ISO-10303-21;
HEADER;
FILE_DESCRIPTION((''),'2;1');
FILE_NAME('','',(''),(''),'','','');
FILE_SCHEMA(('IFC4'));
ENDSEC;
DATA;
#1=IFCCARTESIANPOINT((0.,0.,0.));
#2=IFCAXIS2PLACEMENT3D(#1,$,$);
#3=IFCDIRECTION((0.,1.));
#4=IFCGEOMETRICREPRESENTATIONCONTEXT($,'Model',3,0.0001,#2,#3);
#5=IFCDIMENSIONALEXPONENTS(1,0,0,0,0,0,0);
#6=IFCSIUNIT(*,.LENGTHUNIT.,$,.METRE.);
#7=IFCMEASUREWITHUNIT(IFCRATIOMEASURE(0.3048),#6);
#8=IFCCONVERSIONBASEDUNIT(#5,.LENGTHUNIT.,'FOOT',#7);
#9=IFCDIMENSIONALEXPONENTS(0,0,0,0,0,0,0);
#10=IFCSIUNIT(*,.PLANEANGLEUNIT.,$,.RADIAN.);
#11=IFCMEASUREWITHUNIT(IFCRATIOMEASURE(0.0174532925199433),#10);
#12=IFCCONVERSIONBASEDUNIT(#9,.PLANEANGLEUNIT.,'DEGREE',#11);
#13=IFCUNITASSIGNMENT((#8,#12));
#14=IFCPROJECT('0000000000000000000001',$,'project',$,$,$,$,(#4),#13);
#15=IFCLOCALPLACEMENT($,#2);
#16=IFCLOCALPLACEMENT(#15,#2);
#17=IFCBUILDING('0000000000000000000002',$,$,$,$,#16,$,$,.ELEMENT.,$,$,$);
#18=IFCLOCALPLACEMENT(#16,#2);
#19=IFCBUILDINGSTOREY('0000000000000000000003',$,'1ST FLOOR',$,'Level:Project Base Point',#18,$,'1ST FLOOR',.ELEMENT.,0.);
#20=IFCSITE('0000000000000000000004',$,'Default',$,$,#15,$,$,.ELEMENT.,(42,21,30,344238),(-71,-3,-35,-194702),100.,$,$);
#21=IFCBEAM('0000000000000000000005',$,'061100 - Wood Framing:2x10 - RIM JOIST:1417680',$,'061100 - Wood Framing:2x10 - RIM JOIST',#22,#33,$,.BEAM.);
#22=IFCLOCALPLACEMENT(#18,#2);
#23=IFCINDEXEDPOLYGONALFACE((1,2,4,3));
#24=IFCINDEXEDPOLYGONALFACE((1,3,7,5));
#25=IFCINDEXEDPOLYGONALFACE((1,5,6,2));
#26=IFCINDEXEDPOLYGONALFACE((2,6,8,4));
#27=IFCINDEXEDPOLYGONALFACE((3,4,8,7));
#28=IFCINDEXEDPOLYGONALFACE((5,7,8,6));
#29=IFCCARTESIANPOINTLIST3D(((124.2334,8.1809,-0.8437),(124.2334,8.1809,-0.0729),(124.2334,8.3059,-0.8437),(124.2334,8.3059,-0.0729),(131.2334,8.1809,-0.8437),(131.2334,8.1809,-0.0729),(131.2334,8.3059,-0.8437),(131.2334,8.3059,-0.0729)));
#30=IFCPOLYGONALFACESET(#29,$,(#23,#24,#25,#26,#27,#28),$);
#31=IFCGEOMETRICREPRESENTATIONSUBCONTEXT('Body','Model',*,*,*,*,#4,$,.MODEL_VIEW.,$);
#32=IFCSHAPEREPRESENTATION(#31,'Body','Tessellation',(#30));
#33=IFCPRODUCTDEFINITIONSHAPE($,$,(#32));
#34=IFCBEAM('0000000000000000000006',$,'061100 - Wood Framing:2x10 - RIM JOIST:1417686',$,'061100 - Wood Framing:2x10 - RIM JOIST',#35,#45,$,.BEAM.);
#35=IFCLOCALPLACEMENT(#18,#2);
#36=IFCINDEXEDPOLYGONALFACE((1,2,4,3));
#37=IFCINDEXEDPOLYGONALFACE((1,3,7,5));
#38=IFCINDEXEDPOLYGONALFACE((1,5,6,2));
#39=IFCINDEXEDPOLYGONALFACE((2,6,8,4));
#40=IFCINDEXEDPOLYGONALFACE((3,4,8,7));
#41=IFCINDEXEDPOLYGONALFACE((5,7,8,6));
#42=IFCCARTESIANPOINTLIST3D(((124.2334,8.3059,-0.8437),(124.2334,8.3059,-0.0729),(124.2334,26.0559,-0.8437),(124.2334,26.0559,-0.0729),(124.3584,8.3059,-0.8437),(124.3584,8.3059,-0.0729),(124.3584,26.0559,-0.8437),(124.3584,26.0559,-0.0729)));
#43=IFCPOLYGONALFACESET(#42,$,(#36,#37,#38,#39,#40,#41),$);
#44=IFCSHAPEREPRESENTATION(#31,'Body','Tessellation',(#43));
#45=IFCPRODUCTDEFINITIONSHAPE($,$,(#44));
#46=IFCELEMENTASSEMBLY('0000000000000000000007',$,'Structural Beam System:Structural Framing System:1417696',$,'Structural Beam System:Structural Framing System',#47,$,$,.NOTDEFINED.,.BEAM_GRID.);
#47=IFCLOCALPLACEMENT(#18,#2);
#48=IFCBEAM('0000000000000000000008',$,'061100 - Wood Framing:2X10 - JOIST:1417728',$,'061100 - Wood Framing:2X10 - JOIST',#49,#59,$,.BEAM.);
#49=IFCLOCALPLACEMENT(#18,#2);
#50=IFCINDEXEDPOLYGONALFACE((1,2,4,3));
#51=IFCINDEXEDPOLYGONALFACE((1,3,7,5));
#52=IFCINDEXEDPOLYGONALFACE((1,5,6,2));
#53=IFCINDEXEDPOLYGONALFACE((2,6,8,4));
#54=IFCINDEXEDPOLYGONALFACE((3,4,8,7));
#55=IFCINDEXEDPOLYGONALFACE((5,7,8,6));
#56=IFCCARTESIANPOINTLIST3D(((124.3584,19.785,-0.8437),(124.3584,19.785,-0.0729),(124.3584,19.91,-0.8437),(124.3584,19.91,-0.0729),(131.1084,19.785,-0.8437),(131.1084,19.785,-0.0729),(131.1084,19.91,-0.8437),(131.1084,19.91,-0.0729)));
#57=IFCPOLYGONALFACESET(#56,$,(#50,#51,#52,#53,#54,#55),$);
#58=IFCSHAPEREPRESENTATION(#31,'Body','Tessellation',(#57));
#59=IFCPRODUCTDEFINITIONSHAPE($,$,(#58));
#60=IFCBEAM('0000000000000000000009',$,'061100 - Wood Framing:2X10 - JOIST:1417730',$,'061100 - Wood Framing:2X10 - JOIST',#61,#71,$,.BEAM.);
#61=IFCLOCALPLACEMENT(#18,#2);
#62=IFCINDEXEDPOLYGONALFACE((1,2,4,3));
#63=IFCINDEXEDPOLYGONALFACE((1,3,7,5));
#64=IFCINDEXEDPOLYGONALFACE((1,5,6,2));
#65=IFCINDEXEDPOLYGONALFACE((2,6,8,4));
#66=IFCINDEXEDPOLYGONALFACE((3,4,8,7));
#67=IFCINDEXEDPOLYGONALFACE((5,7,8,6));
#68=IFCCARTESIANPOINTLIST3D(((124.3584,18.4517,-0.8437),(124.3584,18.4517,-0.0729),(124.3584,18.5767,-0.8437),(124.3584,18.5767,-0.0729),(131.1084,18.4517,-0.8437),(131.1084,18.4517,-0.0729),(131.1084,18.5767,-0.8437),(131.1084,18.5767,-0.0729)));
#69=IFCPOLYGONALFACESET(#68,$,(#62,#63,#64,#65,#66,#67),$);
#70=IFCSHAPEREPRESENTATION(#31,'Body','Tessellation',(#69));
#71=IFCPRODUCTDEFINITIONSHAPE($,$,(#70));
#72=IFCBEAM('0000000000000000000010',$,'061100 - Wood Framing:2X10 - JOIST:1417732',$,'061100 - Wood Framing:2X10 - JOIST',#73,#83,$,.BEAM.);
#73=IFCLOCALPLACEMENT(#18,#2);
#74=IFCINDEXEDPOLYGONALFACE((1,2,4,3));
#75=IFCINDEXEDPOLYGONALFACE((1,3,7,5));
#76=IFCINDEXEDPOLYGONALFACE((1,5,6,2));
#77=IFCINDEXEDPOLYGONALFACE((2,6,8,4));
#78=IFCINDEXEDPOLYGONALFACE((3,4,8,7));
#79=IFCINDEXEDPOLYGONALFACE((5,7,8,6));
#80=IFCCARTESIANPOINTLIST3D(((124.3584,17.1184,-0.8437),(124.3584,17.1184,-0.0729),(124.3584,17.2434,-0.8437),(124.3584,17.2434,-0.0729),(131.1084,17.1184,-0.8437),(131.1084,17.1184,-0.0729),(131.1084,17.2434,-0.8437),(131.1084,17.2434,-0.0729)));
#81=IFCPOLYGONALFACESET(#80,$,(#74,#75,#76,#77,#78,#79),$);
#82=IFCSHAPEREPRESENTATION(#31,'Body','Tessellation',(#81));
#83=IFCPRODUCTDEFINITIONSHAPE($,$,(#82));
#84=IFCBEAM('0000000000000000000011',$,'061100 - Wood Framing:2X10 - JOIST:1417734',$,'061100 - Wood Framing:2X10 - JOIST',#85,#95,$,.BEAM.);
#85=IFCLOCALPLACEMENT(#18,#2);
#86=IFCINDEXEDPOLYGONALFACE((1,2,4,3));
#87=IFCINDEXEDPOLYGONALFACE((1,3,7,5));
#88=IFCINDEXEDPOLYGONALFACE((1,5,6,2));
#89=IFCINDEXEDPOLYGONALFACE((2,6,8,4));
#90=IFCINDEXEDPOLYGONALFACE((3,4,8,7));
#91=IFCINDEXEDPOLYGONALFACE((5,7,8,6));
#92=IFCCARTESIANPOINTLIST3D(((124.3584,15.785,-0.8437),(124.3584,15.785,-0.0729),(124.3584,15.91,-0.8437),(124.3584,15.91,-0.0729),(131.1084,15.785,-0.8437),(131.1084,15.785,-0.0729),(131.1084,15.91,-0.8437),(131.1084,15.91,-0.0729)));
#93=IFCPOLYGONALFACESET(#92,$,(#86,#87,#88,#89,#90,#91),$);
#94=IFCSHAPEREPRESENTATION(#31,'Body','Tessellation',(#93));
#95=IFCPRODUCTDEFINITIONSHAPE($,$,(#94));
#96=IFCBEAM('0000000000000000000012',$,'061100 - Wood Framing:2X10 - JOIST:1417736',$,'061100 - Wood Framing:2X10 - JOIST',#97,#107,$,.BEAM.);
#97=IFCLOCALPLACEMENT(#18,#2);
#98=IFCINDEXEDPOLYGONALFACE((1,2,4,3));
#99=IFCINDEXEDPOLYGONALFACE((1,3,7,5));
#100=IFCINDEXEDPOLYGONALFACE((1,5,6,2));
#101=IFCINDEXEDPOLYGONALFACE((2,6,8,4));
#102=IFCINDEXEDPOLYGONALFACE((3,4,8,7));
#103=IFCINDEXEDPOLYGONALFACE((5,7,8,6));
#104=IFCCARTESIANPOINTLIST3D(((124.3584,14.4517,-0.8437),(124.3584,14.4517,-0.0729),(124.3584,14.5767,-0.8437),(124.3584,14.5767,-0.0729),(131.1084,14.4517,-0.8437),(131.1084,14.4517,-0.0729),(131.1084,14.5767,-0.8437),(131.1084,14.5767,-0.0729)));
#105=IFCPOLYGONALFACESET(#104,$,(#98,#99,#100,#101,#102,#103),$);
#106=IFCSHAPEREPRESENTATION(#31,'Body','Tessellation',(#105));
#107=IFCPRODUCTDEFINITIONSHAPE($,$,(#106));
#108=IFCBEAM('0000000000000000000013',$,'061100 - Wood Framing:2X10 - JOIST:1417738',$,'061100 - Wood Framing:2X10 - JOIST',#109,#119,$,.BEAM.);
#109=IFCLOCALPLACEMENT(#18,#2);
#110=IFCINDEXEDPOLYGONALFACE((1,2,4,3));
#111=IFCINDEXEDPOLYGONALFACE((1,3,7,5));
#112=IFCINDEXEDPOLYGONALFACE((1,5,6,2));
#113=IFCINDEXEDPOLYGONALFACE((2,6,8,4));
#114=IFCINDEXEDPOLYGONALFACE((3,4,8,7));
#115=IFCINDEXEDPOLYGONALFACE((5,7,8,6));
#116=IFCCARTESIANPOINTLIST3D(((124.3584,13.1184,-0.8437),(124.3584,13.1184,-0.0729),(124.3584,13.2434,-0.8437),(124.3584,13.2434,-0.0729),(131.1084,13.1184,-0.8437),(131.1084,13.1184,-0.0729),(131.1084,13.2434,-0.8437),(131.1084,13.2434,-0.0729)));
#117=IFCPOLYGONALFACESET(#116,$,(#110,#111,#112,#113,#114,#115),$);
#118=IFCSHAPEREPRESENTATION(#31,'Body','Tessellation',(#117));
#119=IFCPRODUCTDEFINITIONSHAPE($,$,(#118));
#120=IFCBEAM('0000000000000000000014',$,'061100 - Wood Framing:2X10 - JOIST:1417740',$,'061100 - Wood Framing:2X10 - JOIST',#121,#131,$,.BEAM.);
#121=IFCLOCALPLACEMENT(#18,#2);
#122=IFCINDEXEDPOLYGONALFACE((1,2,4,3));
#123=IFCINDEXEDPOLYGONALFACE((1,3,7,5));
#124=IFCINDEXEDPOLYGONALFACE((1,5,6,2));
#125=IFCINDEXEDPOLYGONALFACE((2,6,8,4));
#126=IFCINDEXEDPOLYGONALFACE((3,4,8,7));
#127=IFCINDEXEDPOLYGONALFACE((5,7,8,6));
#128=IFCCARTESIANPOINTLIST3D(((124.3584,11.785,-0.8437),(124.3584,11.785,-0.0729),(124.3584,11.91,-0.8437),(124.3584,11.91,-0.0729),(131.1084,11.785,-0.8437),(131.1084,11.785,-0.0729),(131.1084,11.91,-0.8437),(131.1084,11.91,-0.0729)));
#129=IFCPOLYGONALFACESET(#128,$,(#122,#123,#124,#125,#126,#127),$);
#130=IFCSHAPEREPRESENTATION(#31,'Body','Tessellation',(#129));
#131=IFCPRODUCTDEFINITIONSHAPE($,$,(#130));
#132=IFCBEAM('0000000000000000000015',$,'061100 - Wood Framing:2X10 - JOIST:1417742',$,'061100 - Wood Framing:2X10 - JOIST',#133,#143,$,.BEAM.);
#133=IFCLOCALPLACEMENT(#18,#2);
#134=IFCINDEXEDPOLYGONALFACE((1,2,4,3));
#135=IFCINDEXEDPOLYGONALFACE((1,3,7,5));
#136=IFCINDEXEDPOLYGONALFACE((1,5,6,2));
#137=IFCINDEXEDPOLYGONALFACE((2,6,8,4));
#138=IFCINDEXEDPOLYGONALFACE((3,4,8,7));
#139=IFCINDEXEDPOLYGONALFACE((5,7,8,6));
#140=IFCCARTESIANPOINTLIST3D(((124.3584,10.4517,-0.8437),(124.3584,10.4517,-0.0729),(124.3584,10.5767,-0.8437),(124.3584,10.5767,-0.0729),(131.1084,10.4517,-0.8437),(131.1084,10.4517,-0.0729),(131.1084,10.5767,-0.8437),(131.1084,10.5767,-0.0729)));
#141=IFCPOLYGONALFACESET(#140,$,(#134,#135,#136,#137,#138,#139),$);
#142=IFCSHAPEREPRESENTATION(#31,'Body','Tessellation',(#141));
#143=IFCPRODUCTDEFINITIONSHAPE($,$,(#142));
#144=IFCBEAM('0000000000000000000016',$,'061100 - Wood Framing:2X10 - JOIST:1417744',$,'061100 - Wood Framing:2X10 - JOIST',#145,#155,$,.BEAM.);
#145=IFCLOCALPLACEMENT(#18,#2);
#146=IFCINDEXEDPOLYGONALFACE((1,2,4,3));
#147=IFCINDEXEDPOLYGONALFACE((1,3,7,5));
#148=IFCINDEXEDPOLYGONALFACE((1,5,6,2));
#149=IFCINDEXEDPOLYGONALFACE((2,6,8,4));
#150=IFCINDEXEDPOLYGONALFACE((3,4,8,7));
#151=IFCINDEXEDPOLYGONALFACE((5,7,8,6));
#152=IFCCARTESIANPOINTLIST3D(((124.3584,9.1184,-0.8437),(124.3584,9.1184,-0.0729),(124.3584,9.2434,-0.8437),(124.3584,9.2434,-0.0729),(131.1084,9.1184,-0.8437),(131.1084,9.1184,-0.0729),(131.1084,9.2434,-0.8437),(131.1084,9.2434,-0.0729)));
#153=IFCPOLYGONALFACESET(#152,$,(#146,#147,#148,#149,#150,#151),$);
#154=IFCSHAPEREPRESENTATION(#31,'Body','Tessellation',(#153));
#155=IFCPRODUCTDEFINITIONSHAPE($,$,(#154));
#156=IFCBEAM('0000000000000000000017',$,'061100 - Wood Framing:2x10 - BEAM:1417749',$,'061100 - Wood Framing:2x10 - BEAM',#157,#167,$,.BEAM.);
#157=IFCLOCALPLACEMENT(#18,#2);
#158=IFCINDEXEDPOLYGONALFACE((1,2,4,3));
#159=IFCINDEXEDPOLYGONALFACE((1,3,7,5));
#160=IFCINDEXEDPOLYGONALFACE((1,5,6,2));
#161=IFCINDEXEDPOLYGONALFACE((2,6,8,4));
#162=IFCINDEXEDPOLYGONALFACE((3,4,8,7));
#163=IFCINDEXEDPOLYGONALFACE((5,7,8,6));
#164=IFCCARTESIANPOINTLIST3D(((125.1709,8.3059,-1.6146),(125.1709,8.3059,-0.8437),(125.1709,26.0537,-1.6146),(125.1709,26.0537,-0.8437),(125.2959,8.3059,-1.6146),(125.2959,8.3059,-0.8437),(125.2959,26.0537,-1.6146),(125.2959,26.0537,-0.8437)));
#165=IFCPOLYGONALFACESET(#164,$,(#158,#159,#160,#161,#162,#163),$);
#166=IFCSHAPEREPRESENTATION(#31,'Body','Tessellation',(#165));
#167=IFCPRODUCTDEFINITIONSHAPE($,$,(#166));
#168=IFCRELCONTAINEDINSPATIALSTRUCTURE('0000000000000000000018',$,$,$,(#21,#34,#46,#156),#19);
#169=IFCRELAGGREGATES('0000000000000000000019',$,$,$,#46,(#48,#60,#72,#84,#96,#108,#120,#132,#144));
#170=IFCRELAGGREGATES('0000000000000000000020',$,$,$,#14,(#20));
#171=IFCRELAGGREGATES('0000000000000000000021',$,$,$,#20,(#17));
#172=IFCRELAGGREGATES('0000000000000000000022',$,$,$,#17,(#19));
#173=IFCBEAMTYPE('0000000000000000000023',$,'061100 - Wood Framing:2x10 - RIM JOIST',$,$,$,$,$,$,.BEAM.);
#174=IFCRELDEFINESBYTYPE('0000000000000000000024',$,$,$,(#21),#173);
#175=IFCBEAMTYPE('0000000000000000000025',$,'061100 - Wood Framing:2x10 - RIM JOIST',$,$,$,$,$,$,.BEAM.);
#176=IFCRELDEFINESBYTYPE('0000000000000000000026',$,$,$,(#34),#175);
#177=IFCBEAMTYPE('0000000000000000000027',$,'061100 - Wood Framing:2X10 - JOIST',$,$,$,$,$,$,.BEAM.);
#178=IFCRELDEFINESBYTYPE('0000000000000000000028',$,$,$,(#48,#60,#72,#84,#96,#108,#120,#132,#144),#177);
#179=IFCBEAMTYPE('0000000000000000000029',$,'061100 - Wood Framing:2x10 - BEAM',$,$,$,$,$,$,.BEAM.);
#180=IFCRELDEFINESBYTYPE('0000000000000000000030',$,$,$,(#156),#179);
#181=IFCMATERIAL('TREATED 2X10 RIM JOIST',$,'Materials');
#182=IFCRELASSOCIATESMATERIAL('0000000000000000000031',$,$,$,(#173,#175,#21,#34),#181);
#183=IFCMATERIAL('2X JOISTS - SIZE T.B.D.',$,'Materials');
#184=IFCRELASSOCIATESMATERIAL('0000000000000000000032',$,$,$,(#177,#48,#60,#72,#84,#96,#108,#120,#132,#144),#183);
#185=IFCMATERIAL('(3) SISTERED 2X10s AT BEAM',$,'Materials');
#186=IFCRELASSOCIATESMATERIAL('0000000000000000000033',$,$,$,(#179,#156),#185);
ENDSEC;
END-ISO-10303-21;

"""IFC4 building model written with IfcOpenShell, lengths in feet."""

from ifc_helpers import new_model, entity, si_unit, converted_unit, direction, frame, frame_2d, origin, origin_2d_with_axis, place, context, subcontext, project, spatial, rectangle, extrude, source, transform, mapped, material, material_profile, profile_set, profile_usage, type_object, type_shapes, element, aggregate, save


model = new_model("IFC4")

# Units and contexts
model_context = context("Model", 3, precision=0.0001, world=origin(), true_north=direction((0.0, 1.0)))
body_context = subcontext(model_context, "Body", "Model", "MODEL_VIEW")
ifc_project = project(units=[converted_unit("LENGTHUNIT", "FOOT", entity("IfcRatioMeasure", 0.3048), si_unit("LENGTHUNIT", "METRE"), dimensions=[1, 0, 0, 0, 0, 0, 0]), converted_unit("PLANEANGLEUNIT", "DEGREE", entity("IfcRatioMeasure", 0.0174532925199433), si_unit("PLANEANGLEUNIT", "RADIAN"), dimensions=[0, 0, 0, 0, 0, 0, 0])], contexts=[model_context])

# Site, building, storey
site_placement = place(None, origin())
site = spatial("IfcSite", under=ifc_project, at=site_placement, Name="Default", CompositionType="ELEMENT", RefLatitude=(42, 21, 30, 344238), RefLongitude=(-71, -3, -35, -194702), RefElevation=100.0)
building_placement = place(site_placement, origin())
building = spatial("IfcBuilding", under=site, at=building_placement, CompositionType="ELEMENT")
storey_placement = place(building_placement, origin())
storey = spatial("IfcBuildingStorey", under=building, at=storey_placement, Name="1ST FLOOR", ObjectType="Level:Project Base Point", LongName="1ST FLOOR", CompositionType="ELEMENT", Elevation=0.0)

# Beams
ifc_material_1 = material(Name="TREATED 2X10 RIM JOIST", Category="Materials")
ifc_material_profile_1 = material_profile(ifc_material_1, rectangle(XDim=0.7708, YDim=0.125, at=origin_2d_with_axis()), Name="2x10 - RIM JOIST")
ifc_profile_set_1 = profile_set([ifc_material_profile_1], Name="2x10 - RIM JOIST")
ifc_profile_usage_1 = profile_usage(ifc_profile_set_1, cardinal=8)
beam_type_1 = type_object("IfcBeamType", Name="061100 - Wood Framing:2x10 - RIM JOIST", PredefinedType="BEAM", material=ifc_profile_set_1)
shared_shape_1 = source(origin(), body_context, "Body", "SweptSolid", [
    extrude(rectangle(XDim=0.7708, YDim=0.125, at=origin_2d_with_axis()), frame((-3.5, 0.0, 0.0), z_axis=(1.0, 0.0, 0.0), x_axis=(0.0, 0.0, -1.0)), (0.0, 0.0, 1.0), 7.0),
])
type_shapes(beam_type_1, [shared_shape_1])
beam_1_placement = place(storey_placement, frame((127.7334, 8.2434, -0.4583)))
element("IfcBeam", 1, at=beam_1_placement, inside=storey, type_object=beam_type_1, material=ifc_profile_usage_1, Name="061100 - Wood Framing:2x10 - RIM JOIST:1417680", ObjectType="061100 - Wood Framing:2x10 - RIM JOIST", PredefinedType="BEAM", context=body_context, shape_type="MappedRepresentation", body=[
    mapped(shared_shape_1, transform((0.0, 0.0, 0.0), scale=1.0)),
])
ifc_profile_usage_2 = profile_usage(ifc_profile_set_1, cardinal=8)
beam_type_2 = type_object("IfcBeamType", Name="061100 - Wood Framing:2x10 - RIM JOIST", PredefinedType="BEAM", material=ifc_profile_set_1)
shared_shape_2 = source(origin(), body_context, "Body", "SweptSolid", [
    extrude(rectangle(XDim=0.7708, YDim=0.125, at=frame_2d((0.0, 0.0), x_axis=(1.0, 0.0))), frame((-8.875, 0.0, 0.0), z_axis=(1.0, 0.0, 0.0), x_axis=(0.0, 0.0, -1.0)), (0.0, 0.0, 1.0), 17.75),
])
type_shapes(beam_type_2, [shared_shape_2])
beam_2_placement = place(storey_placement, frame((124.2959, 17.1809, -0.4583), z_axis=(0.0, 0.0, 1.0), x_axis=(0.0, -1.0, 0.0)))
element("IfcBeam", 2, at=beam_2_placement, inside=storey, type_object=beam_type_2, material=ifc_profile_usage_2, Name="061100 - Wood Framing:2x10 - RIM JOIST:1417686", ObjectType="061100 - Wood Framing:2x10 - RIM JOIST", PredefinedType="BEAM", context=body_context, shape_type="MappedRepresentation", body=[
    mapped(shared_shape_2, transform((0.0, 0.0, 0.0), scale=1.0)),
])

# Element assembly, beams
assembly_placement = place(storey_placement, origin())
assembly = element("IfcElementAssembly", 3, at=assembly_placement, inside=storey, Name="Structural Beam System:Structural Framing System:1417696", ObjectType="Structural Beam System:Structural Framing System", AssemblyPlace="NOTDEFINED", PredefinedType="BEAM_GRID")
ifc_material_2 = material(Name="2X JOISTS - SIZE T.B.D.", Category="Materials")
ifc_material_profile_2 = material_profile(ifc_material_2, rectangle(XDim=0.7708, YDim=0.125, at=frame_2d((0.0, 0.0), x_axis=(1.0, 0.0))), Name="2X10 - JOIST")
ifc_profile_set_2 = profile_set([ifc_material_profile_2], Name="2X10 - JOIST")
ifc_profile_usage_3 = profile_usage(ifc_profile_set_2, cardinal=8)
beam_type_3 = type_object("IfcBeamType", Name="061100 - Wood Framing:2X10 - JOIST", PredefinedType="BEAM", material=ifc_profile_set_2)
shared_shape_3 = source(origin(), body_context, "Body", "SweptSolid", [
    extrude(rectangle(XDim=0.7708, YDim=0.125, at=frame_2d((0.0, 0.0), x_axis=(1.0, 0.0))), frame((-3.375, 0.0, 0.0), z_axis=(1.0, 0.0, 0.0), x_axis=(0.0, 0.0, -1.0)), (0.0, 0.0, 1.0), 6.75),
])
type_shapes(beam_type_3, [shared_shape_3])
beam_3_placement = place(assembly_placement, frame((127.7334, 19.8475, -0.4583)))
beam_3 = element("IfcBeam", 4, at=beam_3_placement, type_object=beam_type_3, material=ifc_profile_usage_3, Name="061100 - Wood Framing:2X10 - JOIST:1417728", ObjectType="061100 - Wood Framing:2X10 - JOIST", PredefinedType="BEAM", context=body_context, shape_type="MappedRepresentation", body=[
    mapped(shared_shape_3, transform((0.0, 0.0, 0.0), scale=1.0)),
])
ifc_profile_usage_4 = profile_usage(ifc_profile_set_2, cardinal=8)
beam_4_placement = place(assembly_placement, frame((127.7334, 18.5142, -0.4583)))
beam_4 = element("IfcBeam", 5, at=beam_4_placement, type_object=beam_type_3, material=ifc_profile_usage_4, Name="061100 - Wood Framing:2X10 - JOIST:1417730", ObjectType="061100 - Wood Framing:2X10 - JOIST", PredefinedType="BEAM", context=body_context, shape_type="MappedRepresentation", body=[
    mapped(shared_shape_3, transform((0.0, 0.0, 0.0), scale=1.0)),
])
ifc_profile_usage_5 = profile_usage(ifc_profile_set_2, cardinal=8)
beam_5_placement = place(assembly_placement, frame((127.7334, 17.1809, -0.4583)))
beam_5 = element("IfcBeam", 6, at=beam_5_placement, type_object=beam_type_3, material=ifc_profile_usage_5, Name="061100 - Wood Framing:2X10 - JOIST:1417732", ObjectType="061100 - Wood Framing:2X10 - JOIST", PredefinedType="BEAM", context=body_context, shape_type="MappedRepresentation", body=[
    mapped(shared_shape_3, transform((0.0, 0.0, 0.0), scale=1.0)),
])
ifc_profile_usage_6 = profile_usage(ifc_profile_set_2, cardinal=8)
beam_6_placement = place(assembly_placement, frame((127.7334, 15.8475, -0.4583)))
beam_6 = element("IfcBeam", 7, at=beam_6_placement, type_object=beam_type_3, material=ifc_profile_usage_6, Name="061100 - Wood Framing:2X10 - JOIST:1417734", ObjectType="061100 - Wood Framing:2X10 - JOIST", PredefinedType="BEAM", context=body_context, shape_type="MappedRepresentation", body=[
    mapped(shared_shape_3, transform((0.0, 0.0, 0.0), scale=1.0)),
])
ifc_profile_usage_7 = profile_usage(ifc_profile_set_2, cardinal=8)
beam_7_placement = place(assembly_placement, frame((127.7334, 14.5142, -0.4583)))
beam_7 = element("IfcBeam", 8, at=beam_7_placement, type_object=beam_type_3, material=ifc_profile_usage_7, Name="061100 - Wood Framing:2X10 - JOIST:1417736", ObjectType="061100 - Wood Framing:2X10 - JOIST", PredefinedType="BEAM", context=body_context, shape_type="MappedRepresentation", body=[
    mapped(shared_shape_3, transform((0.0, 0.0, 0.0), scale=1.0)),
])
ifc_profile_usage_8 = profile_usage(ifc_profile_set_2, cardinal=8)
beam_8_placement = place(assembly_placement, frame((127.7334, 13.1809, -0.4583)))
beam_8 = element("IfcBeam", 9, at=beam_8_placement, type_object=beam_type_3, material=ifc_profile_usage_8, Name="061100 - Wood Framing:2X10 - JOIST:1417738", ObjectType="061100 - Wood Framing:2X10 - JOIST", PredefinedType="BEAM", context=body_context, shape_type="MappedRepresentation", body=[
    mapped(shared_shape_3, transform((0.0, 0.0, 0.0), scale=1.0)),
])
ifc_profile_usage_9 = profile_usage(ifc_profile_set_2, cardinal=8)
beam_9_placement = place(assembly_placement, frame((127.7334, 11.8475, -0.4583)))
beam_9 = element("IfcBeam", 10, at=beam_9_placement, type_object=beam_type_3, material=ifc_profile_usage_9, Name="061100 - Wood Framing:2X10 - JOIST:1417740", ObjectType="061100 - Wood Framing:2X10 - JOIST", PredefinedType="BEAM", context=body_context, shape_type="MappedRepresentation", body=[
    mapped(shared_shape_3, transform((0.0, 0.0, 0.0), scale=1.0)),
])
ifc_profile_usage_10 = profile_usage(ifc_profile_set_2, cardinal=8)
beam_10_placement = place(assembly_placement, frame((127.7334, 10.5142, -0.4583)))
beam_10 = element("IfcBeam", 11, at=beam_10_placement, type_object=beam_type_3, material=ifc_profile_usage_10, Name="061100 - Wood Framing:2X10 - JOIST:1417742", ObjectType="061100 - Wood Framing:2X10 - JOIST", PredefinedType="BEAM", context=body_context, shape_type="MappedRepresentation", body=[
    mapped(shared_shape_3, transform((0.0, 0.0, 0.0), scale=1.0)),
])
ifc_profile_usage_11 = profile_usage(ifc_profile_set_2, cardinal=8)
beam_11_placement = place(assembly_placement, frame((127.7334, 9.1809, -0.4583)))
beam_11 = element("IfcBeam", 12, at=beam_11_placement, type_object=beam_type_3, material=ifc_profile_usage_11, Name="061100 - Wood Framing:2X10 - JOIST:1417744", ObjectType="061100 - Wood Framing:2X10 - JOIST", PredefinedType="BEAM", context=body_context, shape_type="MappedRepresentation", body=[
    mapped(shared_shape_3, transform((0.0, 0.0, 0.0), scale=1.0)),
])
aggregate(assembly, [beam_3, beam_4, beam_5, beam_6, beam_7, beam_8, beam_9, beam_10, beam_11])

# Beam
ifc_material_3 = material(Name="(3) SISTERED 2X10s AT BEAM", Category="Materials")
ifc_material_profile_3 = material_profile(ifc_material_3, rectangle(XDim=0.7708, YDim=0.125, at=frame_2d((0.0, 0.0), x_axis=(1.0, 0.0))), Name="2x10 - BEAM")
ifc_profile_set_3 = profile_set([ifc_material_profile_3], Name="2x10 - BEAM")
ifc_profile_usage_12 = profile_usage(ifc_profile_set_3, cardinal=8)
beam_type_4 = type_object("IfcBeamType", Name="061100 - Wood Framing:2x10 - BEAM", PredefinedType="BEAM", material=ifc_profile_set_3)
shared_shape_4 = source(origin(), body_context, "Body", "SweptSolid", [
    extrude(rectangle(XDim=0.7708, YDim=0.125, at=frame_2d((0.0, 0.0), x_axis=(1.0, 0.0))), frame((-8.8427, 0.0, 0.0), z_axis=(1.0, 0.0, 0.0), x_axis=(0.0, 0.0, -1.0)), (0.0, 0.0, 1.0), 17.7478),
])
type_shapes(beam_type_4, [shared_shape_4])
beam_12_placement = place(storey_placement, frame((125.2334, 17.1485, -1.2292), z_axis=(0.0, 0.0, 1.0), x_axis=(0.0, 1.0, 0.0)))
element("IfcBeam", 13, at=beam_12_placement, inside=storey, type_object=beam_type_4, material=ifc_profile_usage_12, Name="061100 - Wood Framing:2x10 - BEAM:1417749", ObjectType="061100 - Wood Framing:2x10 - BEAM", PredefinedType="BEAM", context=body_context, shape_type="MappedRepresentation", body=[
    mapped(shared_shape_4, transform((0.0, 0.0, 0.0), scale=1.0)),
])

save(model, "model.ifc")
